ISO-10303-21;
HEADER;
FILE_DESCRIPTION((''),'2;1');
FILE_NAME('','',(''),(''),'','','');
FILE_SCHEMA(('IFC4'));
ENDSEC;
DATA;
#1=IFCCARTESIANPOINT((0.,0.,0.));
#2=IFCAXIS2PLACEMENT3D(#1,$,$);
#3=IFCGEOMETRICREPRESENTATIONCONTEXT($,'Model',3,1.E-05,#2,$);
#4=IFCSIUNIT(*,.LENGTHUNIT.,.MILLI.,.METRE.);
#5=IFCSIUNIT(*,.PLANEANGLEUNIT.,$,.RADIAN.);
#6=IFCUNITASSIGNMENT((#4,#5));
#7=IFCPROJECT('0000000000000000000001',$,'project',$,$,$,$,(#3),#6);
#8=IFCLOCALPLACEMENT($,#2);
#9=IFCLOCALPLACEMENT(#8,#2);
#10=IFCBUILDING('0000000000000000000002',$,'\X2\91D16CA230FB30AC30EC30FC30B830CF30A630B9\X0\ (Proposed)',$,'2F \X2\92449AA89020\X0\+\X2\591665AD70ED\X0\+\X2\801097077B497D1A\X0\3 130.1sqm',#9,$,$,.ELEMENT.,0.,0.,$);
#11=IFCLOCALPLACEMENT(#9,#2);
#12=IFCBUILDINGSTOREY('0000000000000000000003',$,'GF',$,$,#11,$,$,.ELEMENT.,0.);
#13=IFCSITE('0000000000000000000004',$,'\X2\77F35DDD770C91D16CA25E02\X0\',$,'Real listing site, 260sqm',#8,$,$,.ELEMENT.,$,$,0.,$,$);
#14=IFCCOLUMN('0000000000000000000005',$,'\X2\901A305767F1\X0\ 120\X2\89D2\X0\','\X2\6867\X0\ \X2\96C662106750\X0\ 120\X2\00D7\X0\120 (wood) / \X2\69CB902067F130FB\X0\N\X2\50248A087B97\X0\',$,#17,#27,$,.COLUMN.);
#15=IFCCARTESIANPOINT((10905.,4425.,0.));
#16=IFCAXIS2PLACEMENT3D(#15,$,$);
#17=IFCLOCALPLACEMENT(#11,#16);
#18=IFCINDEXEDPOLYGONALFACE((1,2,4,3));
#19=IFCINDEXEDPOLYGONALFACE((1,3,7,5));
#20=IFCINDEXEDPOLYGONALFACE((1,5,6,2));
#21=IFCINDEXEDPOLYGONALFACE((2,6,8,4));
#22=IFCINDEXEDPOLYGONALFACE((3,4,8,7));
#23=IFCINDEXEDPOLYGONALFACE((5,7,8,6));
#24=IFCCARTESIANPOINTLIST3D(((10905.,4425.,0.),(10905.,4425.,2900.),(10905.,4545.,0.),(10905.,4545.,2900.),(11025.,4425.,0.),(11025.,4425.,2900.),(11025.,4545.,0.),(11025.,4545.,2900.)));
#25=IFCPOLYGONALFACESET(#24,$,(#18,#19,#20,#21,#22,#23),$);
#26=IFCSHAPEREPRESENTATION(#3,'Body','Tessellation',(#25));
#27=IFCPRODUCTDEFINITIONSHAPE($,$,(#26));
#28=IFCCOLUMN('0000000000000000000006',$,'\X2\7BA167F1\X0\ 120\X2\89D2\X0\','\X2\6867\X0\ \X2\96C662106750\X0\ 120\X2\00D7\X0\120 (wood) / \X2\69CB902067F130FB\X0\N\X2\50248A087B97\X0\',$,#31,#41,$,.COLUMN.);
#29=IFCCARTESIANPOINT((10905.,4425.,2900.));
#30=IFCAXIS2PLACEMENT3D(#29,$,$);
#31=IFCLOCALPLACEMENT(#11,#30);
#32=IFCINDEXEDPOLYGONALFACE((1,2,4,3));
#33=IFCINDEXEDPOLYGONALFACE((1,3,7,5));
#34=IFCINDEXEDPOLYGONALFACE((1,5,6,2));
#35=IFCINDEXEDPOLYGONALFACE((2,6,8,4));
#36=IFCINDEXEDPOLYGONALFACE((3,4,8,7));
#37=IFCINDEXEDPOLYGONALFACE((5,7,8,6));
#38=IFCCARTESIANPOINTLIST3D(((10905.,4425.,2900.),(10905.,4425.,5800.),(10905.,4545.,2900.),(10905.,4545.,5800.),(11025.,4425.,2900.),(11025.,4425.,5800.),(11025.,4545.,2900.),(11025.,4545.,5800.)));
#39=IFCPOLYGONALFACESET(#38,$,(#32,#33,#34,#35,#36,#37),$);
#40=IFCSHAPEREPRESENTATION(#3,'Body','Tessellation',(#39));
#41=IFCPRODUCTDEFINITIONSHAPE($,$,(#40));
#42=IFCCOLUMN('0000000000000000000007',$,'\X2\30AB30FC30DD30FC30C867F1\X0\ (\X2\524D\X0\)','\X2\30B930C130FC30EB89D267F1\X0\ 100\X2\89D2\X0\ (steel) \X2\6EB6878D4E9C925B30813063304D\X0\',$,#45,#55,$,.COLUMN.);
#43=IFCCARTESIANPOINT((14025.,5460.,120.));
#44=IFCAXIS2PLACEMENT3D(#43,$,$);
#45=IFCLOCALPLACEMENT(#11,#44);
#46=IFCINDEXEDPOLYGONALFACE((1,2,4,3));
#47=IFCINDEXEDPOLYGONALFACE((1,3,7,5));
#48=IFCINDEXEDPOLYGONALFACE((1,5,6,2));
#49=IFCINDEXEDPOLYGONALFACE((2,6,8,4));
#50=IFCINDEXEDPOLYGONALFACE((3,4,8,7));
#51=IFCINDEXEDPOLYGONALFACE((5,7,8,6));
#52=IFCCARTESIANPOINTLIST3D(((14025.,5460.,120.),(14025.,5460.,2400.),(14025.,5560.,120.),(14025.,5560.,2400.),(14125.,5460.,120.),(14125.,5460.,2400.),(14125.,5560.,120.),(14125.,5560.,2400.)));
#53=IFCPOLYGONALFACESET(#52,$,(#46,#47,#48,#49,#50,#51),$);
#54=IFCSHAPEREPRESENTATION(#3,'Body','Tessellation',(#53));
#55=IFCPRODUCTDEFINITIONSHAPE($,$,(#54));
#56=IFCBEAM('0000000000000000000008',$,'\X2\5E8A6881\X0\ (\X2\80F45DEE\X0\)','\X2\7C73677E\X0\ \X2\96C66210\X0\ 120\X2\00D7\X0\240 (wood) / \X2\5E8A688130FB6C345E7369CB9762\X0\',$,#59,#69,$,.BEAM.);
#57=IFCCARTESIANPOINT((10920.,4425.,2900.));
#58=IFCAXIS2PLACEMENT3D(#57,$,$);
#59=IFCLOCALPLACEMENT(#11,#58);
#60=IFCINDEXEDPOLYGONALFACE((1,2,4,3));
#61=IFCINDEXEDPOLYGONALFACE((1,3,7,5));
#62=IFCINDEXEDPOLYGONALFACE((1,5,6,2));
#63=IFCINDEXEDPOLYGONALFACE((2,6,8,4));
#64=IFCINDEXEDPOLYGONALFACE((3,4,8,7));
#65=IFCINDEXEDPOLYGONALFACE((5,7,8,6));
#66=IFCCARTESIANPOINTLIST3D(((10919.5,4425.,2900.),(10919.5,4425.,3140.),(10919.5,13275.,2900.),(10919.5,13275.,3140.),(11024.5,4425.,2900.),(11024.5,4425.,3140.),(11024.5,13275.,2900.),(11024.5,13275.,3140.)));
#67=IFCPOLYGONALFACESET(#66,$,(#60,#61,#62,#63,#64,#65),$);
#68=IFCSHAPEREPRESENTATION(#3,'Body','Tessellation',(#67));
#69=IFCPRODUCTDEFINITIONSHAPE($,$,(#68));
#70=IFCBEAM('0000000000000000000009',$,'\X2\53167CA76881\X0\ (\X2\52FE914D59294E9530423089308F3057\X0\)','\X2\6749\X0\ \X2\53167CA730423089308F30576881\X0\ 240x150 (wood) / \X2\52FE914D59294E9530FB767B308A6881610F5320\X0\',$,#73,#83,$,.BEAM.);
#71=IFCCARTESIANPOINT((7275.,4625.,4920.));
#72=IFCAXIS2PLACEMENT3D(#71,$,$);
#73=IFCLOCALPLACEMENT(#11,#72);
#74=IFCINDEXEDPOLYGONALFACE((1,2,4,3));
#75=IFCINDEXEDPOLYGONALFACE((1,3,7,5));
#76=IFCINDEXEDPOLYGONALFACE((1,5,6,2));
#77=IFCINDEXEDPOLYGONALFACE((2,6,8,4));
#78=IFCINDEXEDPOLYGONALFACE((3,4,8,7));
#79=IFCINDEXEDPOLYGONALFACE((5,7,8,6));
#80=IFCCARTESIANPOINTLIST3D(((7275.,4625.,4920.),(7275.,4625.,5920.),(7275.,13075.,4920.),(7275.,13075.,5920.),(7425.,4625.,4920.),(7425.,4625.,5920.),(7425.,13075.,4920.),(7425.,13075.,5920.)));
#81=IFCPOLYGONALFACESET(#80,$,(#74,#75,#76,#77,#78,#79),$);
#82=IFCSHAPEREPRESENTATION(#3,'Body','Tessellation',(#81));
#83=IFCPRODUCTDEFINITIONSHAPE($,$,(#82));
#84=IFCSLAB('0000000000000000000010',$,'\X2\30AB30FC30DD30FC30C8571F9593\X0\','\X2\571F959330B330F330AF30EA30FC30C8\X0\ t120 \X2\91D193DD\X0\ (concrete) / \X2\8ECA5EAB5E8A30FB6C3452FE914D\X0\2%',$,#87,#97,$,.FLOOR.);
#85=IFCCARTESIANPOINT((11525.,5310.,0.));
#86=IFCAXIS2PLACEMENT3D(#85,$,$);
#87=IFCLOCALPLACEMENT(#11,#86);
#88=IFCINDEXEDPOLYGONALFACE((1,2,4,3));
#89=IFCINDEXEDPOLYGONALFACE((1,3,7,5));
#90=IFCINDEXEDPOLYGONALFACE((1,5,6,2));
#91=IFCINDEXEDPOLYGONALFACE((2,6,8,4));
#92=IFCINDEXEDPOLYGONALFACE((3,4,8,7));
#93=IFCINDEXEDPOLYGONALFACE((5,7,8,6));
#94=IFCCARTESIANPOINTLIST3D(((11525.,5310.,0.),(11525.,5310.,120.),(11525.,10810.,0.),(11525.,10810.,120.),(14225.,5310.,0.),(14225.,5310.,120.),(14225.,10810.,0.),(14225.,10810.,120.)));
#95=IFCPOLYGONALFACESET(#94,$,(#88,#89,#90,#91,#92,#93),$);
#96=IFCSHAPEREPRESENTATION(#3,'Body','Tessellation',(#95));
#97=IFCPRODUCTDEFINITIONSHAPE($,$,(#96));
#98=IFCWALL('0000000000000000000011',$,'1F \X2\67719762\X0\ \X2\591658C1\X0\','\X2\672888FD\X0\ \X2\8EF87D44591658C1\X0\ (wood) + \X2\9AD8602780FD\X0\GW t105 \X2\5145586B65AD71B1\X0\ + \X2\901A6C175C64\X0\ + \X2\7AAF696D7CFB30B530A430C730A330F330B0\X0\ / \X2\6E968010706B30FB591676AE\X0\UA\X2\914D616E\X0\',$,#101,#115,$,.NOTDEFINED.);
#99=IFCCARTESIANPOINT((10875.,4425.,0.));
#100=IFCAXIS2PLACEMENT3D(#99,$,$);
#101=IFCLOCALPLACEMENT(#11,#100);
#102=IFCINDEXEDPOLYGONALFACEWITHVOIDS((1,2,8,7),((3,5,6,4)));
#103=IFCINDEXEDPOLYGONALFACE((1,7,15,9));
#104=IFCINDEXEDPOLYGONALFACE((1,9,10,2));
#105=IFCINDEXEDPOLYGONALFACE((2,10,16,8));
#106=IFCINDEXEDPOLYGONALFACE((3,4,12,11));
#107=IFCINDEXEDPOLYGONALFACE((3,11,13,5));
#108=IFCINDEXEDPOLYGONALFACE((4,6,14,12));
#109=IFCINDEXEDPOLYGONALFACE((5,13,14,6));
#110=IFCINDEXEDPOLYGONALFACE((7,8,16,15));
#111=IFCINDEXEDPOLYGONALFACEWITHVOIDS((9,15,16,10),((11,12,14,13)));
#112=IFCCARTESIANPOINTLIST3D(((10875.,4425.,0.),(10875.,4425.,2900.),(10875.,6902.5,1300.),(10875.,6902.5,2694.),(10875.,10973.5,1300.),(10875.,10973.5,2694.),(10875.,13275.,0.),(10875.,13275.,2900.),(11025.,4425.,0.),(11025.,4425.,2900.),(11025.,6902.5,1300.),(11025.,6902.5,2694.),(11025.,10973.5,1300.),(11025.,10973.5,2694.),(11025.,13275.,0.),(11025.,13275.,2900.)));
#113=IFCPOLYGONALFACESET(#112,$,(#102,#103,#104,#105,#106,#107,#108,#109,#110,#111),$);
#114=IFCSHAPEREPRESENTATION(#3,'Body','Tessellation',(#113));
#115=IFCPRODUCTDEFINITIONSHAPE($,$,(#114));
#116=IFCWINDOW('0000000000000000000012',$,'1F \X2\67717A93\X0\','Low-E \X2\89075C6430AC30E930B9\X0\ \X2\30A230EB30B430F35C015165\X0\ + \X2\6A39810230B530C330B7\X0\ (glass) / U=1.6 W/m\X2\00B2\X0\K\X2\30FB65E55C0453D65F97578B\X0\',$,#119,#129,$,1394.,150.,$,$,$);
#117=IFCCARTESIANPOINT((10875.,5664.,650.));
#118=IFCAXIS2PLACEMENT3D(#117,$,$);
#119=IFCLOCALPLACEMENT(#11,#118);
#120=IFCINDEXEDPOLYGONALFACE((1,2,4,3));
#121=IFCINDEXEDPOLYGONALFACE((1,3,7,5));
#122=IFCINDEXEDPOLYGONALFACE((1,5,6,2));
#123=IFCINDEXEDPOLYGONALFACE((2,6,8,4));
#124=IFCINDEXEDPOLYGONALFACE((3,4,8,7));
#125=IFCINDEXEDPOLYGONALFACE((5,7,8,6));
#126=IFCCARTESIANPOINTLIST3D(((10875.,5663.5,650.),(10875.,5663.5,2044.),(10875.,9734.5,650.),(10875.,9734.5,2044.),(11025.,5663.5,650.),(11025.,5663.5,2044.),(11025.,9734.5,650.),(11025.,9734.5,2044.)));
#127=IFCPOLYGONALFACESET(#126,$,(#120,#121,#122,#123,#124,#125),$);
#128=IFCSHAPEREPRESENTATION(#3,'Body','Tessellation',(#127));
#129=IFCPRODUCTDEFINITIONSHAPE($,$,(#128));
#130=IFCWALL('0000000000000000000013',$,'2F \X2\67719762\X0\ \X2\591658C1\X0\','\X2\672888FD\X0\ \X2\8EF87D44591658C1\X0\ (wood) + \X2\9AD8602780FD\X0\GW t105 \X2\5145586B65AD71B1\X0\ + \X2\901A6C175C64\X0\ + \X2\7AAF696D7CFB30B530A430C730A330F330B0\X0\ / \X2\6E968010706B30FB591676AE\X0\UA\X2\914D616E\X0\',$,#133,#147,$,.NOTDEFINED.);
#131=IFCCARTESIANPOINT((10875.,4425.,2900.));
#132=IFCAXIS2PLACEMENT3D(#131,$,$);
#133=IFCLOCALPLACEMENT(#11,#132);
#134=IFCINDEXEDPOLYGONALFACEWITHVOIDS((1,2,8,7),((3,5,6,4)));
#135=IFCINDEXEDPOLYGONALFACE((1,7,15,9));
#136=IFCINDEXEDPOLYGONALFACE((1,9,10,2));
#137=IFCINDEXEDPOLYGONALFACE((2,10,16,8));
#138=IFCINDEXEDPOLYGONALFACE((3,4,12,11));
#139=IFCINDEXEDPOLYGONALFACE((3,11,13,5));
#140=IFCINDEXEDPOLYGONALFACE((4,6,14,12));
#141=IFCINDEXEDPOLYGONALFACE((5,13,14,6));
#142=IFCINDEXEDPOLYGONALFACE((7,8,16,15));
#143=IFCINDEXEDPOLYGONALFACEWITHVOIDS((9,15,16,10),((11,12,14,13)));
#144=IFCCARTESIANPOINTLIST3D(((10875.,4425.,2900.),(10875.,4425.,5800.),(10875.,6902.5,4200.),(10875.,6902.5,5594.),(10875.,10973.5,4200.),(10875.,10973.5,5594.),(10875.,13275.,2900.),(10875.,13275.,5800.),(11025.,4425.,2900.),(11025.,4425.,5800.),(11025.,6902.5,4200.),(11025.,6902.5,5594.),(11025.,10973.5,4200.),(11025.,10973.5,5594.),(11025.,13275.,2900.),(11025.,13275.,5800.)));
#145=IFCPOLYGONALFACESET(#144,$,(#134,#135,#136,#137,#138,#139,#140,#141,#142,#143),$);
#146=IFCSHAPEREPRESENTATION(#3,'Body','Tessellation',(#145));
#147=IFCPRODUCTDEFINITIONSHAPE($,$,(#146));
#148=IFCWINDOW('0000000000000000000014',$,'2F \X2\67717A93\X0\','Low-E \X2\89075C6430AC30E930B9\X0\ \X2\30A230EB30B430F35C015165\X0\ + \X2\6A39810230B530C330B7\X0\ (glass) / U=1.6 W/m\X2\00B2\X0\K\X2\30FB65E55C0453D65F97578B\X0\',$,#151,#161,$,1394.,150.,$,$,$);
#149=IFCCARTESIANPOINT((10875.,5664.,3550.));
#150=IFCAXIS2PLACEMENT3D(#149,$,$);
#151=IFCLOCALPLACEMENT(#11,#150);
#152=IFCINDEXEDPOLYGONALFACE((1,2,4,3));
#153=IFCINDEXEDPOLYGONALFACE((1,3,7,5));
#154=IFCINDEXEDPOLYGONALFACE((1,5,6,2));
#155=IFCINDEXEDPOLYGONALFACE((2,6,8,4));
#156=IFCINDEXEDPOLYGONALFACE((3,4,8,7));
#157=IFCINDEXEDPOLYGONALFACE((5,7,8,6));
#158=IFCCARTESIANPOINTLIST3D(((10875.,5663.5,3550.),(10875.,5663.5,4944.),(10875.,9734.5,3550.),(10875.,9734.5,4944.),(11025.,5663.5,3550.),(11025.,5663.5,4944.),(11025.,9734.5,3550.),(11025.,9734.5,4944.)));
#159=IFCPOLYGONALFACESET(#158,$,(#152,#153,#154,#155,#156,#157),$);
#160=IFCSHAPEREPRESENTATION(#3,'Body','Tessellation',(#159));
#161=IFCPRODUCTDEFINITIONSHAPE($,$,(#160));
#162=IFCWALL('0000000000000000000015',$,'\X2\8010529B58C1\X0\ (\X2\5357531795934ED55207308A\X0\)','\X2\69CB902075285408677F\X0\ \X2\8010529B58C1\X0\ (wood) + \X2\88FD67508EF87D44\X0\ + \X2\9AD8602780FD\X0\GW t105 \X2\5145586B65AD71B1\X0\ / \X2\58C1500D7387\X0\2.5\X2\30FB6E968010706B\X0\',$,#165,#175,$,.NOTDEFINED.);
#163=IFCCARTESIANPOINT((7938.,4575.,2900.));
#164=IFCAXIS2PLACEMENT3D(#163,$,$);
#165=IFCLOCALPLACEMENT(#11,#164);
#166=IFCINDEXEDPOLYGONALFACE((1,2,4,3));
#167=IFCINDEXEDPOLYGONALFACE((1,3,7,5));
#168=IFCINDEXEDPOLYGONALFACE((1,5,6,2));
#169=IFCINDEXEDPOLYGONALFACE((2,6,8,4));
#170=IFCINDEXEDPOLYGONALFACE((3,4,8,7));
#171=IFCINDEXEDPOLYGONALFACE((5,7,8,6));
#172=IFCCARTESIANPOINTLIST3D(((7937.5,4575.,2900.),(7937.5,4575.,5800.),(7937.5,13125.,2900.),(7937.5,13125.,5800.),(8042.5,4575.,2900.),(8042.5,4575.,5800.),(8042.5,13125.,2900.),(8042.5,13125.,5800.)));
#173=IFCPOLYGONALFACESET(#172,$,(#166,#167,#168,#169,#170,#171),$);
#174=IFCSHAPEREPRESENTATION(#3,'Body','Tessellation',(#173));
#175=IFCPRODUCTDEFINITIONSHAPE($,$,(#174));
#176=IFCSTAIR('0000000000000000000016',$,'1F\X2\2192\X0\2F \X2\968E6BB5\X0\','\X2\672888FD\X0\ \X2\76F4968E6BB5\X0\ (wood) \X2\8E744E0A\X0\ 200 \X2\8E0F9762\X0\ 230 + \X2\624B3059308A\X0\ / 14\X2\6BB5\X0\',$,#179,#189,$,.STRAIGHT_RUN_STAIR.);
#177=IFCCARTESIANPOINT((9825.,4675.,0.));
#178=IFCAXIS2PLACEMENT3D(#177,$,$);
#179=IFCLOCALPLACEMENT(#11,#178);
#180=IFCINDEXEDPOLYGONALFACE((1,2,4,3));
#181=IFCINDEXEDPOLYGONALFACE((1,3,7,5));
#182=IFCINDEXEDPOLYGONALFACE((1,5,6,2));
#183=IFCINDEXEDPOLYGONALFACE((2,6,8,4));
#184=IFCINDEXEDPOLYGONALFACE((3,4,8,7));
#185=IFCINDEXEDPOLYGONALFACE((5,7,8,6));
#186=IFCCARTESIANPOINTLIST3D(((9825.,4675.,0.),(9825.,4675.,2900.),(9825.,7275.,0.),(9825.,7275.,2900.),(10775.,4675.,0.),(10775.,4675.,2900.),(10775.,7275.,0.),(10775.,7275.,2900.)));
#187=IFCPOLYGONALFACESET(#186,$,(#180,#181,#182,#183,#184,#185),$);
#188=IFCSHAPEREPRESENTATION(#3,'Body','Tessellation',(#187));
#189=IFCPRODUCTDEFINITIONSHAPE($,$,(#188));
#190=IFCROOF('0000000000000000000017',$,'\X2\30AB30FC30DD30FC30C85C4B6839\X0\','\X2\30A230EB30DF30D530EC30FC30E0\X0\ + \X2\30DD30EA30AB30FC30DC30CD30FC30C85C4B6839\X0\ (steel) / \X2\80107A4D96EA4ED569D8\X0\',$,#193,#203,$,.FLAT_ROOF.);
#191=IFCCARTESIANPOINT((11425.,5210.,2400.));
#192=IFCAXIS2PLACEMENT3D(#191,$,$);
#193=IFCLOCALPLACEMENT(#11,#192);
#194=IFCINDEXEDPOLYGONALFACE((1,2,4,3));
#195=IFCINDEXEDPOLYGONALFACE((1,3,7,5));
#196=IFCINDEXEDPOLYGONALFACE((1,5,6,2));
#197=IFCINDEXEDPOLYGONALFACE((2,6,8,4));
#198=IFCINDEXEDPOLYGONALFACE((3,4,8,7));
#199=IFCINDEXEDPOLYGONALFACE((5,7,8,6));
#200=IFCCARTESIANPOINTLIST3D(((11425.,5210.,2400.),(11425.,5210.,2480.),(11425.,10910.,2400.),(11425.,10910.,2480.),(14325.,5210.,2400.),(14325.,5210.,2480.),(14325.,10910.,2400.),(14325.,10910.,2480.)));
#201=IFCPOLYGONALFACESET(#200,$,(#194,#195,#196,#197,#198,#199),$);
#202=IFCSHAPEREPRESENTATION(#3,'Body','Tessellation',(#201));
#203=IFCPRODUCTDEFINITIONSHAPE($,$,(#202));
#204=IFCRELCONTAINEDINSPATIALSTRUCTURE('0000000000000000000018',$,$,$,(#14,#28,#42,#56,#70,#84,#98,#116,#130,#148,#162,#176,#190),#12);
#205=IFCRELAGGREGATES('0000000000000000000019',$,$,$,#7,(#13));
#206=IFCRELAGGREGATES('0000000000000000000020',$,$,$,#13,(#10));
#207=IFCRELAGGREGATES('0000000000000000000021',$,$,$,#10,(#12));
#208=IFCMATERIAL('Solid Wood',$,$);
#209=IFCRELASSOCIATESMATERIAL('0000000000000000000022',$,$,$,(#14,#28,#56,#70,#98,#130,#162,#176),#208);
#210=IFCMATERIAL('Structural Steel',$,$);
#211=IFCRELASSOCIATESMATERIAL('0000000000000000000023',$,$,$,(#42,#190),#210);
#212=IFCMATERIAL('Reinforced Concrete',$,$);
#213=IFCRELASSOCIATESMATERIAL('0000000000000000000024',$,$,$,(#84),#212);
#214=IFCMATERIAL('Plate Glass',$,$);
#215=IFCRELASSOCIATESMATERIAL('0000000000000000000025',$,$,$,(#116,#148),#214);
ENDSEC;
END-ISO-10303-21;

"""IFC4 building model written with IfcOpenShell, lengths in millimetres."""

from ifc_helpers import new_model, si_unit, frame, frame_2d, origin, place, context, project, spatial, rectangle, extrude, material, element, fill, save


model = new_model("IFC4")

# Units and contexts
model_context = context("Model", 3, precision=1e-05, world=origin())
ifc_project = project(units=[si_unit("LENGTHUNIT", "METRE", prefix="MILLI"), si_unit("PLANEANGLEUNIT", "RADIAN")], contexts=[model_context])

# Site, building, storey
site_placement = place(None, origin())
site = spatial("IfcSite", under=ifc_project, at=site_placement, Name="石川県金沢市", ObjectType="Real listing site, 260sqm", CompositionType="ELEMENT", RefElevation=0.0)
building_placement = place(site_placement, origin())
building = spatial("IfcBuilding", under=site, at=building_placement, Name="金沢・ガレージハウス (Proposed)", ObjectType="2F 鉄骨造+外断热+耐震等級3 130.1sqm", CompositionType="ELEMENT", ElevationOfRefHeight=0.0, ElevationOfTerrain=0.0)
storey_placement = place(building_placement, origin())
storey = spatial("IfcBuildingStorey", under=building, at=storey_placement, Name="GF", CompositionType="ELEMENT", Elevation=0.0)

# Columns
ifc_material_1 = material(Name="Solid Wood")
column_1_placement = place(storey_placement, frame((10905.0, 4425.0, 0.0)))
element("IfcColumn", 1, at=column_1_placement, inside=storey, material=ifc_material_1, Name="通し柱 120角", Description="桧 集成材 120×120 (wood) / 構造柱・N値計算", PredefinedType="COLUMN", context=model_context, shape_type="SweptSolid", body=[
    extrude(rectangle(XDim=120.0, YDim=120.0, at=frame_2d((60.0, 60.0))), frame((10905.0, 4425.0, 0.0)), (0.0, 0.0, 1.0), 2900.0),
])
column_2_placement = place(storey_placement, frame((10905.0, 4425.0, 2900.0)))
element("IfcColumn", 2, at=column_2_placement, inside=storey, material=ifc_material_1, Name="管柱 120角", Description="桧 集成材 120×120 (wood) / 構造柱・N値計算", PredefinedType="COLUMN", context=model_context, shape_type="SweptSolid", body=[
    extrude(rectangle(XDim=120.0, YDim=120.0, at=frame_2d((60.0, 60.0))), frame((10905.0, 4425.0, 2900.0)), (0.0, 0.0, 1.0), 2900.0),
])
ifc_material_2 = material(Name="Structural Steel")
column_3_placement = place(storey_placement, frame((14025.0, 5460.0, 120.0)))
element("IfcColumn", 3, at=column_3_placement, inside=storey, material=ifc_material_2, Name="カーポート柱 (前)", Description="スチール角柱 100角 (steel) 溶融亜鉛めっき", PredefinedType="COLUMN", context=model_context, shape_type="SweptSolid", body=[
    extrude(rectangle(XDim=100.0, YDim=100.0, at=frame_2d((50.0, 50.0))), frame((14025.0, 5460.0, 120.0)), (0.0, 0.0, 1.0), 2280.0),
])

# Beams
beam_1_placement = place(storey_placement, frame((10920.0, 4425.0, 2900.0)))
element("IfcBeam", 4, at=beam_1_placement, inside=storey, material=ifc_material_1, Name="床梁 (胴差)", Description="米松 集成 120×240 (wood) / 床梁・水平構面", PredefinedType="BEAM", context=model_context, shape_type="SweptSolid", body=[
    extrude(rectangle(XDim=105.0, YDim=8850.0, at=frame_2d((52.0, 4425.0))), frame((10920.0, 4425.0, 2900.0)), (0.0, 0.0, 1.0), 240.0),
])
beam_2_placement = place(storey_placement, frame((7275.0, 4625.0, 4920.0)))
element("IfcBeam", 5, at=beam_2_placement, inside=storey, material=ifc_material_1, Name="化粧梁 (勾配天井あらわし)", Description="杉 化粧あらわし梁 240x150 (wood) / 勾配天井・登り梁意匠", PredefinedType="BEAM", context=model_context, shape_type="SweptSolid", body=[
    extrude(rectangle(XDim=150.0, YDim=8450.0, at=frame_2d((75.0, 4225.0))), frame((7275.0, 4625.0, 4920.0)), (0.0, 0.0, 1.0), 1000.0),
])

# Slab
ifc_material_3 = material(Name="Reinforced Concrete")
slab_placement = place(storey_placement, frame((11525.0, 5310.0, 0.0)))
element("IfcSlab", 6, at=slab_placement, inside=storey, material=ifc_material_3, Name="カーポート土間", Description="土間コンクリート t120 金鏝 (concrete) / 車庫床・水勾配2%", PredefinedType="FLOOR", context=model_context, shape_type="SweptSolid", body=[
    extrude(rectangle(XDim=2700.0, YDim=5500.0, at=frame_2d((1350.0, 2750.0))), frame((11525.0, 5310.0, 0.0)), (0.0, 0.0, 1.0), 120.0),
])

# Wall, opening, window
wall_1_placement = place(storey_placement, frame((10875.0, 4425.0, 0.0)))
wall_1 = element("IfcWall", 7, at=wall_1_placement, inside=storey, material=ifc_material_1, Name="1F 東面 外壁", Description="木製 軸組外壁 (wood) + 高性能GW t105 充填断熱 + 通気層 + 窯業系サイディング / 準耐火・外皮UA配慮", PredefinedType="NOTDEFINED", context=model_context, shape_type="SweptSolid", body=[
    extrude(rectangle(XDim=150.0, YDim=8850.0, at=frame_2d((75.0, 4425.0))), frame((10875.0, 4425.0, 0.0)), (0.0, 0.0, 1.0), 2900.0),
])
opening_1_placement = place(storey_placement, frame((10875.0, 5664.0, 650.0)))
opening_1 = element("IfcOpeningElement", 8, at=opening_1_placement, cuts=wall_1, PredefinedType="NOTDEFINED", context=model_context, shape_type="SweptSolid", body=[
    extrude(rectangle(XDim=150.0, YDim=4071.0, at=frame_2d((75.0, 2035.0))), frame((10875.0, 5664.0, 650.0)), (0.0, 0.0, 1.0), 1394.0),
])
ifc_material_4 = material(Name="Plate Glass")
window_1_placement = place(storey_placement, frame((10875.0, 5664.0, 650.0)))
window_1 = element("IfcWindow", 9, at=window_1_placement, inside=storey, material=ifc_material_4, Name="1F 東窓", Description="Low-E 複層ガラス アルゴン封入 + 樹脂サッシ (glass) / U=1.6 W/m²K・日射取得型", OverallHeight=1394.0, OverallWidth=150.0, context=model_context, shape_type="SweptSolid", body=[
    extrude(rectangle(XDim=150.0, YDim=4071.0, at=frame_2d((75.0, 2035.0))), frame((10875.0, 5664.0, 650.0)), (0.0, 0.0, 1.0), 1394.0),
])
fill(opening_1, window_1)

# Wall, opening, window
wall_2_placement = place(storey_placement, frame((10875.0, 4425.0, 2900.0)))
wall_2 = element("IfcWall", 10, at=wall_2_placement, inside=storey, material=ifc_material_1, Name="2F 東面 外壁", Description="木製 軸組外壁 (wood) + 高性能GW t105 充填断熱 + 通気層 + 窯業系サイディング / 準耐火・外皮UA配慮", PredefinedType="NOTDEFINED", context=model_context, shape_type="SweptSolid", body=[
    extrude(rectangle(XDim=150.0, YDim=8850.0, at=frame_2d((75.0, 4425.0))), frame((10875.0, 4425.0, 2900.0)), (0.0, 0.0, 1.0), 2900.0),
])
opening_2_placement = place(storey_placement, frame((10875.0, 5664.0, 3550.0)))
opening_2 = element("IfcOpeningElement", 11, at=opening_2_placement, cuts=wall_2, PredefinedType="NOTDEFINED", context=model_context, shape_type="SweptSolid", body=[
    extrude(rectangle(XDim=150.0, YDim=4071.0, at=frame_2d((75.0, 2035.0))), frame((10875.0, 5664.0, 3550.0)), (0.0, 0.0, 1.0), 1394.0),
])
window_2_placement = place(storey_placement, frame((10875.0, 5664.0, 3550.0)))
window_2 = element("IfcWindow", 12, at=window_2_placement, inside=storey, material=ifc_material_4, Name="2F 東窓", Description="Low-E 複層ガラス アルゴン封入 + 樹脂サッシ (glass) / U=1.6 W/m²K・日射取得型", OverallHeight=1394.0, OverallWidth=150.0, context=model_context, shape_type="SweptSolid", body=[
    extrude(rectangle(XDim=150.0, YDim=4071.0, at=frame_2d((75.0, 2035.0))), frame((10875.0, 5664.0, 3550.0)), (0.0, 0.0, 1.0), 1394.0),
])
fill(opening_2, window_2)

# Wall
wall_3_placement = place(storey_placement, frame((7938.0, 4575.0, 2900.0)))
element("IfcWall", 13, at=wall_3_placement, inside=storey, material=ifc_material_1, Name="耐力壁 (南北間仕切り)", Description="構造用合板 耐力壁 (wood) + 製材軸組 + 高性能GW t105 充填断熱 / 壁倍率2.5・準耐火", PredefinedType="NOTDEFINED", context=model_context, shape_type="SweptSolid", body=[
    extrude(rectangle(XDim=105.0, YDim=8550.0, at=frame_2d((52.0, 4275.0))), frame((7938.0, 4575.0, 2900.0)), (0.0, 0.0, 1.0), 2900.0),
])

# Stair
stair_placement = place(storey_placement, frame((9825.0, 4675.0, 0.0)))
element("IfcStair", 14, at=stair_placement, inside=storey, material=ifc_material_1, Name="1F→2F 階段", Description="木製 直階段 (wood) 蹴上 200 踏面 230 + 手すり / 14段", PredefinedType="STRAIGHT_RUN_STAIR", context=model_context, shape_type="SweptSolid", body=[
    extrude(rectangle(XDim=950.0, YDim=2600.0, at=frame_2d((475.0, 1300.0))), frame((9825.0, 4675.0, 0.0)), (0.0, 0.0, 1.0), 2900.0),
])

# Roof
roof_placement = place(storey_placement, frame((11425.0, 5210.0, 2400.0)))
element("IfcRoof", 15, at=roof_placement, inside=storey, material=ifc_material_2, Name="カーポート屋根", Description="アルミフレーム + ポリカーボネート屋根 (steel) / 耐積雪仕様", PredefinedType="FLAT_ROOF", context=model_context, shape_type="SweptSolid", body=[
    extrude(rectangle(XDim=2900.0, YDim=5700.0, at=frame_2d((1450.0, 2850.0))), frame((11425.0, 5210.0, 2400.0)), (0.0, 0.0, 1.0), 80.0),
])

save(model, "model.ifc")
